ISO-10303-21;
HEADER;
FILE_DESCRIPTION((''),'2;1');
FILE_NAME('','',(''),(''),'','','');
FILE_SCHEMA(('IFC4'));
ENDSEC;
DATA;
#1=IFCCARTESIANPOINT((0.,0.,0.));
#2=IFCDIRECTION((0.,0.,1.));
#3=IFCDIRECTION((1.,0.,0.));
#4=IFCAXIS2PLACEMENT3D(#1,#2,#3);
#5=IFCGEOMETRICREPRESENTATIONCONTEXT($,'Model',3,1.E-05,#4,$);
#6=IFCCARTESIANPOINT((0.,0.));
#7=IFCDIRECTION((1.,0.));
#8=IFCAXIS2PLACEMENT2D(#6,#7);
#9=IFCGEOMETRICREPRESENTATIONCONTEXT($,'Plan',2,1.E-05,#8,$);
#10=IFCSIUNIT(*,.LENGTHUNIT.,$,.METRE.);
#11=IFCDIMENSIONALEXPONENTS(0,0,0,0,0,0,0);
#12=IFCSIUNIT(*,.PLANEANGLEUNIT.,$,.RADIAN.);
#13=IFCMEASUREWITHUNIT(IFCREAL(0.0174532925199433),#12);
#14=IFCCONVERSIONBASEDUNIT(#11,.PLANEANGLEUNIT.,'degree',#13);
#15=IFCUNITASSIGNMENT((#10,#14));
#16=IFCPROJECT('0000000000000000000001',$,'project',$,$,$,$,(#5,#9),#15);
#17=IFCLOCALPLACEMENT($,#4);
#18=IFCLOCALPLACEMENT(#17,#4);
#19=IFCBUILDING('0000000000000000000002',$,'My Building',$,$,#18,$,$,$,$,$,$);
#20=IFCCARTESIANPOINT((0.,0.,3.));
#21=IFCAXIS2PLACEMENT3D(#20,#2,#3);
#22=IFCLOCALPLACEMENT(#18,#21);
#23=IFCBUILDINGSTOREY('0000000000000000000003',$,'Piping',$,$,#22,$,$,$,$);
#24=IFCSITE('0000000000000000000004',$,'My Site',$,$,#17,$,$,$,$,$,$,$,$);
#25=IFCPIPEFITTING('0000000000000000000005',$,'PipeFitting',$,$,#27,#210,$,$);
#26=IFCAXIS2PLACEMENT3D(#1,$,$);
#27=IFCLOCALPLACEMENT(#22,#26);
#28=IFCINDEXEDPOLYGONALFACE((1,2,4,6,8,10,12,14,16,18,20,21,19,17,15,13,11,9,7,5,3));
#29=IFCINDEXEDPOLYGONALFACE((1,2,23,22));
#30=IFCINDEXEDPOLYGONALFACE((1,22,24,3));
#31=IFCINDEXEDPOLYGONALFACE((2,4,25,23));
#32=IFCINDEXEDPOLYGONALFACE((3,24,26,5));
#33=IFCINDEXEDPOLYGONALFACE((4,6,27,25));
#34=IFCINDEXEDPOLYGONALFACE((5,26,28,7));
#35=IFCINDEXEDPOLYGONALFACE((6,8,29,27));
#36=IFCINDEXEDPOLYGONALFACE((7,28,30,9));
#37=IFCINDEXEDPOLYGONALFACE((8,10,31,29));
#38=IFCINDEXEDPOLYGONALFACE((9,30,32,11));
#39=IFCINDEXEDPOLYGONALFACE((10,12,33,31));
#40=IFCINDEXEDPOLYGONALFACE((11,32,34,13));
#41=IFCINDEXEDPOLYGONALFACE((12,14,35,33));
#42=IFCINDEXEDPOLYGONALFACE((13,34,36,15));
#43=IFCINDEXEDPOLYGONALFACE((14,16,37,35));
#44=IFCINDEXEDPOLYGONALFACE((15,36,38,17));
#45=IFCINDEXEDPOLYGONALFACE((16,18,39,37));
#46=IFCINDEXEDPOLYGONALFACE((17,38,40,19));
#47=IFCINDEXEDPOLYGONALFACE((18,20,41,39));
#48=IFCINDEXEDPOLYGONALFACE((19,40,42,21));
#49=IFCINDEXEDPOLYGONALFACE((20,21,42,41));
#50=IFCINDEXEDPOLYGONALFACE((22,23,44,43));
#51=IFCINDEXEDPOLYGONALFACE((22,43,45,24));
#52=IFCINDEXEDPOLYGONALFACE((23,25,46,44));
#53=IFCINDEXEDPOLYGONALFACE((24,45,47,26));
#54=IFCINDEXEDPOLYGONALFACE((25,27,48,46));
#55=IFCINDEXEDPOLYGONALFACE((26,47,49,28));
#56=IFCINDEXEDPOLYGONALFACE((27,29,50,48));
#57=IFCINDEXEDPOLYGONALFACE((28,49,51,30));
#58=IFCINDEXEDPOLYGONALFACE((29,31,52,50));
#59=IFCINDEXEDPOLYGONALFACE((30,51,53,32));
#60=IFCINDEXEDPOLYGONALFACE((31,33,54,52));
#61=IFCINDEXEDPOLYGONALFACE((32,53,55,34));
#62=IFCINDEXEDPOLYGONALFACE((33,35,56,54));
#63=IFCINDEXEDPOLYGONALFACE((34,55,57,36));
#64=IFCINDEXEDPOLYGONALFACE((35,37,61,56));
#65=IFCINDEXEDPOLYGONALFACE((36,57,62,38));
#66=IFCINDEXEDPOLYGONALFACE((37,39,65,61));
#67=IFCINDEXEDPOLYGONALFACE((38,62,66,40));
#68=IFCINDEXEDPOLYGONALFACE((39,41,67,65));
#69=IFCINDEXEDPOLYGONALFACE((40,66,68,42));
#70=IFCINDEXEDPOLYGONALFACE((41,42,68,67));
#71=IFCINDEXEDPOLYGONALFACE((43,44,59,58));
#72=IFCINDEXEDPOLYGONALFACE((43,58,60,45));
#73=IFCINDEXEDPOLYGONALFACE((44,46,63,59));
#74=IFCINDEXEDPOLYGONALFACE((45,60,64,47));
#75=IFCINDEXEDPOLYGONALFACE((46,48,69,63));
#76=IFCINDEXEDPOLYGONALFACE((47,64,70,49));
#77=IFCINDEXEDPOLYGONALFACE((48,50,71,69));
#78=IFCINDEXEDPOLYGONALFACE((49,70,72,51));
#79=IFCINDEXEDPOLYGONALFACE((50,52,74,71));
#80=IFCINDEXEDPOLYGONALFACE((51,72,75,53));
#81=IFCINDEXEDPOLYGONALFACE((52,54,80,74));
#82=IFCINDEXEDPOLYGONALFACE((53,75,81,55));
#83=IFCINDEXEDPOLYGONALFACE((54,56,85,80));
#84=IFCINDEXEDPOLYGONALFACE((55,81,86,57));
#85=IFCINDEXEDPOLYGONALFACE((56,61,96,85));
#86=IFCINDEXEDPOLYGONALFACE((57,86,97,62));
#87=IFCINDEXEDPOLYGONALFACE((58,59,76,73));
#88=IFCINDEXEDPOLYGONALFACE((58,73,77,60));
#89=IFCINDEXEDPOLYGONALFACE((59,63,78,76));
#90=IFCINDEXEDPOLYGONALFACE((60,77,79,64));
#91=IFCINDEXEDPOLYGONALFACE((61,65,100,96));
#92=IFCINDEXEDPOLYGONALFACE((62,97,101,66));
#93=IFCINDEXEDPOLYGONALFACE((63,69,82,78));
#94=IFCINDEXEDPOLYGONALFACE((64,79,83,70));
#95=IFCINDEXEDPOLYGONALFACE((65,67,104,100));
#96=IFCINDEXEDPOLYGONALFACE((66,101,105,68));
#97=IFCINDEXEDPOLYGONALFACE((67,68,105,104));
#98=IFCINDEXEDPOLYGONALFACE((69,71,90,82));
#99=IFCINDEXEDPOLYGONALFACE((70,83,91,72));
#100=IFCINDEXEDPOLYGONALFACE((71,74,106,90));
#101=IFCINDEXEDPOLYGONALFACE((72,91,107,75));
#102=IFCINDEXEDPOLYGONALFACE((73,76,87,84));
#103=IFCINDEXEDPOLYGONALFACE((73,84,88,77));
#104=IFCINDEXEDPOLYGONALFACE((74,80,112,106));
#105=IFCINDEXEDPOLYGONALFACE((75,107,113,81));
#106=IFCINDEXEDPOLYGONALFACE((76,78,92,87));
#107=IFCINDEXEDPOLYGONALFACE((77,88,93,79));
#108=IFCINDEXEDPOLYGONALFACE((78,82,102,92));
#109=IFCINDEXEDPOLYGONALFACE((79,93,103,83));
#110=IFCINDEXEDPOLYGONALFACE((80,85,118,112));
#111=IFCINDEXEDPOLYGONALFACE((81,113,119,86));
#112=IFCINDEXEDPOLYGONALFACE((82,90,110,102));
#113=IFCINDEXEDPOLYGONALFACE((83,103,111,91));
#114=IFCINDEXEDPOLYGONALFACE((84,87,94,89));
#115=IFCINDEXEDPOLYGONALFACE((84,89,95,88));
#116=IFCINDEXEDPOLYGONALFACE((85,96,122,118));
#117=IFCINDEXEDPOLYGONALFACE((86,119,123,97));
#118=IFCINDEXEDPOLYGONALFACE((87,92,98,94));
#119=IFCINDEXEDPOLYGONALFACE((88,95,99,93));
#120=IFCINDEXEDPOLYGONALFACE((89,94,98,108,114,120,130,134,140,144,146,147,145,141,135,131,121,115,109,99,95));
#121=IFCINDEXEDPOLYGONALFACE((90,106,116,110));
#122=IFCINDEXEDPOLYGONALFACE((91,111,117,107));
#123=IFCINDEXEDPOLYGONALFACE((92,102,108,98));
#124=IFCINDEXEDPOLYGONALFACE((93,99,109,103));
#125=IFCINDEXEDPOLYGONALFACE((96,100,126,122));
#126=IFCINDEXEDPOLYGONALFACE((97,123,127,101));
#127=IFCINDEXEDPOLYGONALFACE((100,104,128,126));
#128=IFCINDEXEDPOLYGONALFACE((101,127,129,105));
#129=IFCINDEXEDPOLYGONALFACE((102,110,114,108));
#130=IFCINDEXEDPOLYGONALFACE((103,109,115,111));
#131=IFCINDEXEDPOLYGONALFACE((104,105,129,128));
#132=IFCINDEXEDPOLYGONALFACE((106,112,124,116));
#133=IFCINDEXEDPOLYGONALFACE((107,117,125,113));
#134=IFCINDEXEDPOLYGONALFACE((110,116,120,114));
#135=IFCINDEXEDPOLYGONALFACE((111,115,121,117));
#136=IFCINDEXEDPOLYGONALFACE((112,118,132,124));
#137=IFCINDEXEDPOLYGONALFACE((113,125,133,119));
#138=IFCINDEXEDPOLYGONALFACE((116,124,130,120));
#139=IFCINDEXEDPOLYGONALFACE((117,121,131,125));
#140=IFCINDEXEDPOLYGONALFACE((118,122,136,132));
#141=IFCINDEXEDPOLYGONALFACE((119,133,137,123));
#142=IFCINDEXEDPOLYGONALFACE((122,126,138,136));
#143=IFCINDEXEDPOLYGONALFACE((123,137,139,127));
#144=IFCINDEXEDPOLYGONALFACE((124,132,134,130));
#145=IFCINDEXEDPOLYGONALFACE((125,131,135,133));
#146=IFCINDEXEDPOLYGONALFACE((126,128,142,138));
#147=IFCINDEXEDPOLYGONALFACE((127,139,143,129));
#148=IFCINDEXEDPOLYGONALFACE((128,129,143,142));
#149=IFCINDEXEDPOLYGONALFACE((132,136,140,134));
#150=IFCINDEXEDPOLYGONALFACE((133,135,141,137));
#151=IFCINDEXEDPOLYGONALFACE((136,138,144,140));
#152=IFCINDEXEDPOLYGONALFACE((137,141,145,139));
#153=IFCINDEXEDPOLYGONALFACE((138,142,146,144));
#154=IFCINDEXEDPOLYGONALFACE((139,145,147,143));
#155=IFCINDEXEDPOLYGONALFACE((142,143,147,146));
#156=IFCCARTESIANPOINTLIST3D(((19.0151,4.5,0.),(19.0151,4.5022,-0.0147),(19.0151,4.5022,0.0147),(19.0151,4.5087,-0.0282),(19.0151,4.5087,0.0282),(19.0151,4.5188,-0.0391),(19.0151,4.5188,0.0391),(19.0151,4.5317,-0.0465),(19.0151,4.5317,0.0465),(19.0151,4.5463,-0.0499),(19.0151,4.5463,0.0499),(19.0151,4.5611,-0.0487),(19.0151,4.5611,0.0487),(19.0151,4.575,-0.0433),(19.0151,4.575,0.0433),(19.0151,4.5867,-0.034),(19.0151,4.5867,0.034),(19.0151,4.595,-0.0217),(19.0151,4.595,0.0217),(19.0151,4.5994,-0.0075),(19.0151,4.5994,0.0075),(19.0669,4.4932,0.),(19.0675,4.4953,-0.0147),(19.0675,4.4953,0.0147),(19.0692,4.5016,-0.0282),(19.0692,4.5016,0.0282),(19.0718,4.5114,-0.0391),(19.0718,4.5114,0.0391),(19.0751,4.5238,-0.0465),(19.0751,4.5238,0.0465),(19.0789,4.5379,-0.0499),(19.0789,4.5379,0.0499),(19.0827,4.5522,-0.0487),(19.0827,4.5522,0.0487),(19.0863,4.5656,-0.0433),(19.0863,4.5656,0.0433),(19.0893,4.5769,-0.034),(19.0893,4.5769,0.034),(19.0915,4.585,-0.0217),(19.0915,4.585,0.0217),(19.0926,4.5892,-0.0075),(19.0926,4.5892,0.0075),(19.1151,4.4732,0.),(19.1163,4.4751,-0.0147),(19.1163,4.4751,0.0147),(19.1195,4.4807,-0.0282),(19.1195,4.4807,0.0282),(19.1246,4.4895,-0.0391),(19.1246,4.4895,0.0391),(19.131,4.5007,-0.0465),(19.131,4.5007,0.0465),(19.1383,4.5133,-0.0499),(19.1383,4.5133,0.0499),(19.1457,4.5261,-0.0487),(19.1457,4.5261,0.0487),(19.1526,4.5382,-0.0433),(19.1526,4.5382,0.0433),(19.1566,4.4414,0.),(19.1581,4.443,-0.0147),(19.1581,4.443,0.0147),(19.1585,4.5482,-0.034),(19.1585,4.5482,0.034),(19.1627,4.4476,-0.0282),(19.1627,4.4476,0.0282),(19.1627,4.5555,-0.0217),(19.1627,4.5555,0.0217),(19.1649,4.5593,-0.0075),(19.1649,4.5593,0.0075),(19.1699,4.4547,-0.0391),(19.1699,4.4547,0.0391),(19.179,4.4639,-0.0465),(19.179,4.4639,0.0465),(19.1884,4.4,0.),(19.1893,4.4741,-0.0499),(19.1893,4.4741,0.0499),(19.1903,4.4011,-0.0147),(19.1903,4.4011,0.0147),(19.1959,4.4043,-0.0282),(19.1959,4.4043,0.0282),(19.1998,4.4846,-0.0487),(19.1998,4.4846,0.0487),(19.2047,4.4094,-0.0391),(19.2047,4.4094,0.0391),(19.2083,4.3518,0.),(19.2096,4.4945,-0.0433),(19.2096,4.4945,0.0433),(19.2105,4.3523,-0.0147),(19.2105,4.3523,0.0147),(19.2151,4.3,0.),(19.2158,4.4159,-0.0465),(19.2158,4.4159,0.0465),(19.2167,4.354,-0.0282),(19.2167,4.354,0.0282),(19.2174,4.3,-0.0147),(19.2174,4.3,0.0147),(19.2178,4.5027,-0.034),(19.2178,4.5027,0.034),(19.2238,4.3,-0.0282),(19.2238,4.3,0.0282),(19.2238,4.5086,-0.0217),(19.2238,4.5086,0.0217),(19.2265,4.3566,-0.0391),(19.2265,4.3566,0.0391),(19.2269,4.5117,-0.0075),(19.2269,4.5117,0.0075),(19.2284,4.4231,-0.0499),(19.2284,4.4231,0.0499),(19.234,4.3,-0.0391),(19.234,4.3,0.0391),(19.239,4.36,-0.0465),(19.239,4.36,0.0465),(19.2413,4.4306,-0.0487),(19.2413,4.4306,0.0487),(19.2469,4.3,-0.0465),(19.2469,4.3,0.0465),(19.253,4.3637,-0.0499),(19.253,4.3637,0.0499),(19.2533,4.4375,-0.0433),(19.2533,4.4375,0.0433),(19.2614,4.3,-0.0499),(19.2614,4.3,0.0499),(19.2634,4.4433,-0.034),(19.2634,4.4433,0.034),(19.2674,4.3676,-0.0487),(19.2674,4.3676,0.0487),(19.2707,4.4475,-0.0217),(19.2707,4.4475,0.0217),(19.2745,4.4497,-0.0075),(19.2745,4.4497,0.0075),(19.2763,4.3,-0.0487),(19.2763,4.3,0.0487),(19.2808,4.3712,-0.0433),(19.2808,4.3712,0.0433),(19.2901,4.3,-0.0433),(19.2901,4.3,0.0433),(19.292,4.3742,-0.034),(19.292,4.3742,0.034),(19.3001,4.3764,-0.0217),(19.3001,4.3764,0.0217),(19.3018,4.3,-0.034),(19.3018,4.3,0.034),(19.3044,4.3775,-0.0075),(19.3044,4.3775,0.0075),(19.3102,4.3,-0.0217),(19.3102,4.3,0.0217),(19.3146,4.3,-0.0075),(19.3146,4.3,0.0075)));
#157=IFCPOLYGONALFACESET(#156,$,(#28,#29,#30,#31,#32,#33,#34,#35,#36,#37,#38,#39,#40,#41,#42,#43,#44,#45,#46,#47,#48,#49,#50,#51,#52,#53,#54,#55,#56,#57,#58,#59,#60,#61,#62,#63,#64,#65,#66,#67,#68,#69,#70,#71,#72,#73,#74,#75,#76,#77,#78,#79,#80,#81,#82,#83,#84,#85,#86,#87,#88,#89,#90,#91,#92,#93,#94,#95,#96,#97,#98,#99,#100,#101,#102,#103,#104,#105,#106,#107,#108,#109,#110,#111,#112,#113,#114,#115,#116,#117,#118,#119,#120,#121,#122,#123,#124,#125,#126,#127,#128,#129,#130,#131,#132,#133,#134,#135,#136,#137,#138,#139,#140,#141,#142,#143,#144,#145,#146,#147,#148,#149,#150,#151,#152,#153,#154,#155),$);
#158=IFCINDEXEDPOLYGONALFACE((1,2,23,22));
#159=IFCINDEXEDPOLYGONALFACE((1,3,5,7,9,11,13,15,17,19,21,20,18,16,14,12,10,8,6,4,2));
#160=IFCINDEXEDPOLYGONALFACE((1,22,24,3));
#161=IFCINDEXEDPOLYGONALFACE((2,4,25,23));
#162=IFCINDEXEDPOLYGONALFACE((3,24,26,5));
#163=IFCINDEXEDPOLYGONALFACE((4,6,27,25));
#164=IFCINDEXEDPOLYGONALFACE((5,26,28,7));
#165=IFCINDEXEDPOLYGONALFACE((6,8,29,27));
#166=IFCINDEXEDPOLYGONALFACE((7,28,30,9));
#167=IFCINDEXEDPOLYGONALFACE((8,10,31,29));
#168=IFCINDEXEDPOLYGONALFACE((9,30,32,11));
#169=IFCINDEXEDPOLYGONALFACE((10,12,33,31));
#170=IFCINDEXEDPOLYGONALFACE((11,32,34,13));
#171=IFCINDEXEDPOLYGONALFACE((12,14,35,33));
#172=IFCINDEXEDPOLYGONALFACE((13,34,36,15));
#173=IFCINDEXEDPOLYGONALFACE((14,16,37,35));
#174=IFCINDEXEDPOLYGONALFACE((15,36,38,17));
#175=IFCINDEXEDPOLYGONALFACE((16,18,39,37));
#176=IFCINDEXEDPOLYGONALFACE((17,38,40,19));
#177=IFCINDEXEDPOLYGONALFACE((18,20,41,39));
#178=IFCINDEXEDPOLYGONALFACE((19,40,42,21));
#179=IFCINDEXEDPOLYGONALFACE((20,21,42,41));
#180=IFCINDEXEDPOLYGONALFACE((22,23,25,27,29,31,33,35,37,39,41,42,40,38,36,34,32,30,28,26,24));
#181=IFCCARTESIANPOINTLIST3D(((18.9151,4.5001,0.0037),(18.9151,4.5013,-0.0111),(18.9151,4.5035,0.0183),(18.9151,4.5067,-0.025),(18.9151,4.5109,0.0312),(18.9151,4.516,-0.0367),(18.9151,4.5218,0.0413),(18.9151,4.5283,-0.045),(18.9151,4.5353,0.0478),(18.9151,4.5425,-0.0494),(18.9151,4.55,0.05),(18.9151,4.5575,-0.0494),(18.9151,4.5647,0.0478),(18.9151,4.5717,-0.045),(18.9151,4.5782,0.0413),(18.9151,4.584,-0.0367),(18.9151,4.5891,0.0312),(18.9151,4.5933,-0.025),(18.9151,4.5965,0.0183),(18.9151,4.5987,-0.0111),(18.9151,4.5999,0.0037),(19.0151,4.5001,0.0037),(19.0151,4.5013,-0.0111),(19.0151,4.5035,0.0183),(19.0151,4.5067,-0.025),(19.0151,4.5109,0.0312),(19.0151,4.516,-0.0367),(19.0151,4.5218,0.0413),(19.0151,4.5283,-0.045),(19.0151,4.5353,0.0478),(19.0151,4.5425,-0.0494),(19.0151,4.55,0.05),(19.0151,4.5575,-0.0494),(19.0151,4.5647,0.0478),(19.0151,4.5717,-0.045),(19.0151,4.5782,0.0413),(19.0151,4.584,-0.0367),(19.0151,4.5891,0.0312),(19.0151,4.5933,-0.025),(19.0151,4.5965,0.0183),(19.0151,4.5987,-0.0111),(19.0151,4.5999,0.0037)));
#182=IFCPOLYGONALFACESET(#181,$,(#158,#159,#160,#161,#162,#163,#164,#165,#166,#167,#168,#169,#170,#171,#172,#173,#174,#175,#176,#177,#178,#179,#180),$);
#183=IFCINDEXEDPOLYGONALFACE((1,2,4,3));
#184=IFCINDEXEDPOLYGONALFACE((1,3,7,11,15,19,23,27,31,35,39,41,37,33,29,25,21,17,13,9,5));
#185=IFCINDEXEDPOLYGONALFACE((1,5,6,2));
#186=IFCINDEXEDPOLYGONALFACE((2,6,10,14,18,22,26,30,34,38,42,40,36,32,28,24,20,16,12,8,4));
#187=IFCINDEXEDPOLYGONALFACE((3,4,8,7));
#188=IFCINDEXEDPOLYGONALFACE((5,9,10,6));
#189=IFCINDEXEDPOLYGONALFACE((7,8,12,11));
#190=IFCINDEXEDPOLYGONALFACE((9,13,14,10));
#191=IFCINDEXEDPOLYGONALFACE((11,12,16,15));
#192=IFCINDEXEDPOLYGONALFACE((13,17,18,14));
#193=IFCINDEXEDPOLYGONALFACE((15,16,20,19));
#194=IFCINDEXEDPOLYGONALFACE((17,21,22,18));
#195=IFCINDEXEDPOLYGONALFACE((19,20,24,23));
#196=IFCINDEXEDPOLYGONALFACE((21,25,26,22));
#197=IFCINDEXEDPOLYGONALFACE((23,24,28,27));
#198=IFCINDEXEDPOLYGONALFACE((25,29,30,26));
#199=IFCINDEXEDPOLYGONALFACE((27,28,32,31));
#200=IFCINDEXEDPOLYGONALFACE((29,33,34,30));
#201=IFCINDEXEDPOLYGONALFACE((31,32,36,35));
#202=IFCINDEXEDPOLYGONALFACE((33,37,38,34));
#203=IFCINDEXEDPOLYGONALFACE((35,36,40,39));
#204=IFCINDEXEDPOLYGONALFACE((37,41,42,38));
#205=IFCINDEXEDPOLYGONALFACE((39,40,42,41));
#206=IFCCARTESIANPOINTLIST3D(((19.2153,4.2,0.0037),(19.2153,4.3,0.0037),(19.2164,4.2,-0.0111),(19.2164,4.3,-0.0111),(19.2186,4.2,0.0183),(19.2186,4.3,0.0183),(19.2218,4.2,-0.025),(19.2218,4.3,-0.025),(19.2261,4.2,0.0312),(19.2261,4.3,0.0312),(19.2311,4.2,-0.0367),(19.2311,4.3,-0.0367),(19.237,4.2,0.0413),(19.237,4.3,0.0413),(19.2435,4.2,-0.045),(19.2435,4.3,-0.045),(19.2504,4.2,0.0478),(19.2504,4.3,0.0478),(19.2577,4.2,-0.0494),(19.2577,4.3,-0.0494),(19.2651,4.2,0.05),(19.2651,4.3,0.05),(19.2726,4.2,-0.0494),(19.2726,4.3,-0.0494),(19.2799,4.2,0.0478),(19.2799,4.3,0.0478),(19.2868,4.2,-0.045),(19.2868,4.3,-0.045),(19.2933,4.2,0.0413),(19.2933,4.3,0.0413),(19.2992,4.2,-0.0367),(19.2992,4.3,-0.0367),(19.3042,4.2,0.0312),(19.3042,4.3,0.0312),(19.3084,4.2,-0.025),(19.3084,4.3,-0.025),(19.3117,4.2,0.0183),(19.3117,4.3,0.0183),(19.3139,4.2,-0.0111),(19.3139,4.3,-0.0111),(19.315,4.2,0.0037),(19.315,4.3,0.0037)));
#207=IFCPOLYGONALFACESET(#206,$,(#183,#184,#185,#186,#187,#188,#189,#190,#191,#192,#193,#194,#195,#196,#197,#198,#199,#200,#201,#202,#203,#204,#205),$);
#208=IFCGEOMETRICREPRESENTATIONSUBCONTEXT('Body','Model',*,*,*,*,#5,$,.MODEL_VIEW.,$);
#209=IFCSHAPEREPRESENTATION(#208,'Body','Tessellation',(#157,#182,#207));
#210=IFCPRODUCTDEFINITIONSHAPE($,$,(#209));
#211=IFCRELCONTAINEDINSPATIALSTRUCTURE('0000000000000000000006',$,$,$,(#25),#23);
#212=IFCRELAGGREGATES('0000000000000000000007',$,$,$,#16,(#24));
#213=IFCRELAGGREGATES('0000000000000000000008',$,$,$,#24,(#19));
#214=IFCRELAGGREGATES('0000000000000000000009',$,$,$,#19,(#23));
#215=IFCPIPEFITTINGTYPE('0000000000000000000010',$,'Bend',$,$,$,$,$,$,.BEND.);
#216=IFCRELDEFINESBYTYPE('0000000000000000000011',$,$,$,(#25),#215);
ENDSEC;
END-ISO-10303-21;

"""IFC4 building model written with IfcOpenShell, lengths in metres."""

from ifc_helpers import new_model, entity, si_unit, converted_unit, frame, origin_with_axes, origin_2d_with_axis, place, context, subcontext, project, spatial, circle, extrude, source, transform, mapped, type_object, type_shapes, element, save


model = new_model("IFC4")

# Units and contexts
model_context = context("Model", 3, precision=1e-05, world=origin_with_axes())
plan_context = context("Plan", 2, precision=1e-05, world=origin_2d_with_axis())
body_context = subcontext(model_context, "Body", "Model", "MODEL_VIEW")
ifc_project = project(units=[si_unit("LENGTHUNIT", "METRE"), converted_unit("PLANEANGLEUNIT", "degree", entity("IfcReal", 0.0174532925199433), si_unit("PLANEANGLEUNIT", "RADIAN"), dimensions=[0, 0, 0, 0, 0, 0, 0])], contexts=[model_context, plan_context])

# Site, building, storey
site_placement = place(None, origin_with_axes())
site = spatial("IfcSite", under=ifc_project, at=site_placement, Name="My Site")
building_placement = place(site_placement, origin_with_axes())
building = spatial("IfcBuilding", under=site, at=building_placement, Name="My Building")
storey_placement = place(building_placement, frame((0.0, 0.0, 3.0), z_axis=(0.0, 0.0, 1.0), x_axis=(1.0, 0.0, 0.0)))
storey = spatial("IfcBuildingStorey", under=building, at=storey_placement, Name="Piping")

# Pipe fitting
pipe_fitting_type = type_object("IfcPipeFittingType", Name="Bend", PredefinedType="BEND")
shared_shape = source(origin_with_axes(), body_context, "Body", "SolidModel", [
    entity("IfcSweptDiskSolid", entity("IfcIndexedPolyCurve", entity("IfcCartesianPointList3D", [[0.0, 0.0, -0.1], [0.0, -0.0732, -0.2768], [0.0, -0.25, -0.35]]), [entity("IfcArcIndex", [1, 2, 3])]), 0.05),
    extrude(circle(Radius=0.05), origin_with_axes(), (0.0, 0.0, -1.0), 0.1),
    extrude(circle(Radius=0.05), frame((0.0, -0.25, -0.35), z_axis=(0.0, -1.0, 0.0), x_axis=(1.0, 0.0, 0.0)), (0.0, 0.0, 1.0), 0.1),
])
type_shapes(pipe_fitting_type, [shared_shape])
for number, where, z_axis, x_axis, name in (
    (1, (18.9151, 4.55, 0.0), (-1.0, 0.0, 0.0), (0.0, 0.0, 1.0), "PipeFitting"),
):
    element("IfcPipeFitting", number, at=place(storey_placement, frame(where, z_axis=z_axis, x_axis=x_axis)), inside=storey, type_object=pipe_fitting_type, Name=name, context=body_context, shape_type="MappedRepresentation", body=[
        mapped(shared_shape, transform((0.0, 0.0, 0.0), x_axis=(1.0, 0.0, 0.0), y_axis=(0.0, 1.0, 0.0), z_axis=(0.0, 0.0, 1.0), scale=1.0)),
    ])

save(model, "model.ifc")
